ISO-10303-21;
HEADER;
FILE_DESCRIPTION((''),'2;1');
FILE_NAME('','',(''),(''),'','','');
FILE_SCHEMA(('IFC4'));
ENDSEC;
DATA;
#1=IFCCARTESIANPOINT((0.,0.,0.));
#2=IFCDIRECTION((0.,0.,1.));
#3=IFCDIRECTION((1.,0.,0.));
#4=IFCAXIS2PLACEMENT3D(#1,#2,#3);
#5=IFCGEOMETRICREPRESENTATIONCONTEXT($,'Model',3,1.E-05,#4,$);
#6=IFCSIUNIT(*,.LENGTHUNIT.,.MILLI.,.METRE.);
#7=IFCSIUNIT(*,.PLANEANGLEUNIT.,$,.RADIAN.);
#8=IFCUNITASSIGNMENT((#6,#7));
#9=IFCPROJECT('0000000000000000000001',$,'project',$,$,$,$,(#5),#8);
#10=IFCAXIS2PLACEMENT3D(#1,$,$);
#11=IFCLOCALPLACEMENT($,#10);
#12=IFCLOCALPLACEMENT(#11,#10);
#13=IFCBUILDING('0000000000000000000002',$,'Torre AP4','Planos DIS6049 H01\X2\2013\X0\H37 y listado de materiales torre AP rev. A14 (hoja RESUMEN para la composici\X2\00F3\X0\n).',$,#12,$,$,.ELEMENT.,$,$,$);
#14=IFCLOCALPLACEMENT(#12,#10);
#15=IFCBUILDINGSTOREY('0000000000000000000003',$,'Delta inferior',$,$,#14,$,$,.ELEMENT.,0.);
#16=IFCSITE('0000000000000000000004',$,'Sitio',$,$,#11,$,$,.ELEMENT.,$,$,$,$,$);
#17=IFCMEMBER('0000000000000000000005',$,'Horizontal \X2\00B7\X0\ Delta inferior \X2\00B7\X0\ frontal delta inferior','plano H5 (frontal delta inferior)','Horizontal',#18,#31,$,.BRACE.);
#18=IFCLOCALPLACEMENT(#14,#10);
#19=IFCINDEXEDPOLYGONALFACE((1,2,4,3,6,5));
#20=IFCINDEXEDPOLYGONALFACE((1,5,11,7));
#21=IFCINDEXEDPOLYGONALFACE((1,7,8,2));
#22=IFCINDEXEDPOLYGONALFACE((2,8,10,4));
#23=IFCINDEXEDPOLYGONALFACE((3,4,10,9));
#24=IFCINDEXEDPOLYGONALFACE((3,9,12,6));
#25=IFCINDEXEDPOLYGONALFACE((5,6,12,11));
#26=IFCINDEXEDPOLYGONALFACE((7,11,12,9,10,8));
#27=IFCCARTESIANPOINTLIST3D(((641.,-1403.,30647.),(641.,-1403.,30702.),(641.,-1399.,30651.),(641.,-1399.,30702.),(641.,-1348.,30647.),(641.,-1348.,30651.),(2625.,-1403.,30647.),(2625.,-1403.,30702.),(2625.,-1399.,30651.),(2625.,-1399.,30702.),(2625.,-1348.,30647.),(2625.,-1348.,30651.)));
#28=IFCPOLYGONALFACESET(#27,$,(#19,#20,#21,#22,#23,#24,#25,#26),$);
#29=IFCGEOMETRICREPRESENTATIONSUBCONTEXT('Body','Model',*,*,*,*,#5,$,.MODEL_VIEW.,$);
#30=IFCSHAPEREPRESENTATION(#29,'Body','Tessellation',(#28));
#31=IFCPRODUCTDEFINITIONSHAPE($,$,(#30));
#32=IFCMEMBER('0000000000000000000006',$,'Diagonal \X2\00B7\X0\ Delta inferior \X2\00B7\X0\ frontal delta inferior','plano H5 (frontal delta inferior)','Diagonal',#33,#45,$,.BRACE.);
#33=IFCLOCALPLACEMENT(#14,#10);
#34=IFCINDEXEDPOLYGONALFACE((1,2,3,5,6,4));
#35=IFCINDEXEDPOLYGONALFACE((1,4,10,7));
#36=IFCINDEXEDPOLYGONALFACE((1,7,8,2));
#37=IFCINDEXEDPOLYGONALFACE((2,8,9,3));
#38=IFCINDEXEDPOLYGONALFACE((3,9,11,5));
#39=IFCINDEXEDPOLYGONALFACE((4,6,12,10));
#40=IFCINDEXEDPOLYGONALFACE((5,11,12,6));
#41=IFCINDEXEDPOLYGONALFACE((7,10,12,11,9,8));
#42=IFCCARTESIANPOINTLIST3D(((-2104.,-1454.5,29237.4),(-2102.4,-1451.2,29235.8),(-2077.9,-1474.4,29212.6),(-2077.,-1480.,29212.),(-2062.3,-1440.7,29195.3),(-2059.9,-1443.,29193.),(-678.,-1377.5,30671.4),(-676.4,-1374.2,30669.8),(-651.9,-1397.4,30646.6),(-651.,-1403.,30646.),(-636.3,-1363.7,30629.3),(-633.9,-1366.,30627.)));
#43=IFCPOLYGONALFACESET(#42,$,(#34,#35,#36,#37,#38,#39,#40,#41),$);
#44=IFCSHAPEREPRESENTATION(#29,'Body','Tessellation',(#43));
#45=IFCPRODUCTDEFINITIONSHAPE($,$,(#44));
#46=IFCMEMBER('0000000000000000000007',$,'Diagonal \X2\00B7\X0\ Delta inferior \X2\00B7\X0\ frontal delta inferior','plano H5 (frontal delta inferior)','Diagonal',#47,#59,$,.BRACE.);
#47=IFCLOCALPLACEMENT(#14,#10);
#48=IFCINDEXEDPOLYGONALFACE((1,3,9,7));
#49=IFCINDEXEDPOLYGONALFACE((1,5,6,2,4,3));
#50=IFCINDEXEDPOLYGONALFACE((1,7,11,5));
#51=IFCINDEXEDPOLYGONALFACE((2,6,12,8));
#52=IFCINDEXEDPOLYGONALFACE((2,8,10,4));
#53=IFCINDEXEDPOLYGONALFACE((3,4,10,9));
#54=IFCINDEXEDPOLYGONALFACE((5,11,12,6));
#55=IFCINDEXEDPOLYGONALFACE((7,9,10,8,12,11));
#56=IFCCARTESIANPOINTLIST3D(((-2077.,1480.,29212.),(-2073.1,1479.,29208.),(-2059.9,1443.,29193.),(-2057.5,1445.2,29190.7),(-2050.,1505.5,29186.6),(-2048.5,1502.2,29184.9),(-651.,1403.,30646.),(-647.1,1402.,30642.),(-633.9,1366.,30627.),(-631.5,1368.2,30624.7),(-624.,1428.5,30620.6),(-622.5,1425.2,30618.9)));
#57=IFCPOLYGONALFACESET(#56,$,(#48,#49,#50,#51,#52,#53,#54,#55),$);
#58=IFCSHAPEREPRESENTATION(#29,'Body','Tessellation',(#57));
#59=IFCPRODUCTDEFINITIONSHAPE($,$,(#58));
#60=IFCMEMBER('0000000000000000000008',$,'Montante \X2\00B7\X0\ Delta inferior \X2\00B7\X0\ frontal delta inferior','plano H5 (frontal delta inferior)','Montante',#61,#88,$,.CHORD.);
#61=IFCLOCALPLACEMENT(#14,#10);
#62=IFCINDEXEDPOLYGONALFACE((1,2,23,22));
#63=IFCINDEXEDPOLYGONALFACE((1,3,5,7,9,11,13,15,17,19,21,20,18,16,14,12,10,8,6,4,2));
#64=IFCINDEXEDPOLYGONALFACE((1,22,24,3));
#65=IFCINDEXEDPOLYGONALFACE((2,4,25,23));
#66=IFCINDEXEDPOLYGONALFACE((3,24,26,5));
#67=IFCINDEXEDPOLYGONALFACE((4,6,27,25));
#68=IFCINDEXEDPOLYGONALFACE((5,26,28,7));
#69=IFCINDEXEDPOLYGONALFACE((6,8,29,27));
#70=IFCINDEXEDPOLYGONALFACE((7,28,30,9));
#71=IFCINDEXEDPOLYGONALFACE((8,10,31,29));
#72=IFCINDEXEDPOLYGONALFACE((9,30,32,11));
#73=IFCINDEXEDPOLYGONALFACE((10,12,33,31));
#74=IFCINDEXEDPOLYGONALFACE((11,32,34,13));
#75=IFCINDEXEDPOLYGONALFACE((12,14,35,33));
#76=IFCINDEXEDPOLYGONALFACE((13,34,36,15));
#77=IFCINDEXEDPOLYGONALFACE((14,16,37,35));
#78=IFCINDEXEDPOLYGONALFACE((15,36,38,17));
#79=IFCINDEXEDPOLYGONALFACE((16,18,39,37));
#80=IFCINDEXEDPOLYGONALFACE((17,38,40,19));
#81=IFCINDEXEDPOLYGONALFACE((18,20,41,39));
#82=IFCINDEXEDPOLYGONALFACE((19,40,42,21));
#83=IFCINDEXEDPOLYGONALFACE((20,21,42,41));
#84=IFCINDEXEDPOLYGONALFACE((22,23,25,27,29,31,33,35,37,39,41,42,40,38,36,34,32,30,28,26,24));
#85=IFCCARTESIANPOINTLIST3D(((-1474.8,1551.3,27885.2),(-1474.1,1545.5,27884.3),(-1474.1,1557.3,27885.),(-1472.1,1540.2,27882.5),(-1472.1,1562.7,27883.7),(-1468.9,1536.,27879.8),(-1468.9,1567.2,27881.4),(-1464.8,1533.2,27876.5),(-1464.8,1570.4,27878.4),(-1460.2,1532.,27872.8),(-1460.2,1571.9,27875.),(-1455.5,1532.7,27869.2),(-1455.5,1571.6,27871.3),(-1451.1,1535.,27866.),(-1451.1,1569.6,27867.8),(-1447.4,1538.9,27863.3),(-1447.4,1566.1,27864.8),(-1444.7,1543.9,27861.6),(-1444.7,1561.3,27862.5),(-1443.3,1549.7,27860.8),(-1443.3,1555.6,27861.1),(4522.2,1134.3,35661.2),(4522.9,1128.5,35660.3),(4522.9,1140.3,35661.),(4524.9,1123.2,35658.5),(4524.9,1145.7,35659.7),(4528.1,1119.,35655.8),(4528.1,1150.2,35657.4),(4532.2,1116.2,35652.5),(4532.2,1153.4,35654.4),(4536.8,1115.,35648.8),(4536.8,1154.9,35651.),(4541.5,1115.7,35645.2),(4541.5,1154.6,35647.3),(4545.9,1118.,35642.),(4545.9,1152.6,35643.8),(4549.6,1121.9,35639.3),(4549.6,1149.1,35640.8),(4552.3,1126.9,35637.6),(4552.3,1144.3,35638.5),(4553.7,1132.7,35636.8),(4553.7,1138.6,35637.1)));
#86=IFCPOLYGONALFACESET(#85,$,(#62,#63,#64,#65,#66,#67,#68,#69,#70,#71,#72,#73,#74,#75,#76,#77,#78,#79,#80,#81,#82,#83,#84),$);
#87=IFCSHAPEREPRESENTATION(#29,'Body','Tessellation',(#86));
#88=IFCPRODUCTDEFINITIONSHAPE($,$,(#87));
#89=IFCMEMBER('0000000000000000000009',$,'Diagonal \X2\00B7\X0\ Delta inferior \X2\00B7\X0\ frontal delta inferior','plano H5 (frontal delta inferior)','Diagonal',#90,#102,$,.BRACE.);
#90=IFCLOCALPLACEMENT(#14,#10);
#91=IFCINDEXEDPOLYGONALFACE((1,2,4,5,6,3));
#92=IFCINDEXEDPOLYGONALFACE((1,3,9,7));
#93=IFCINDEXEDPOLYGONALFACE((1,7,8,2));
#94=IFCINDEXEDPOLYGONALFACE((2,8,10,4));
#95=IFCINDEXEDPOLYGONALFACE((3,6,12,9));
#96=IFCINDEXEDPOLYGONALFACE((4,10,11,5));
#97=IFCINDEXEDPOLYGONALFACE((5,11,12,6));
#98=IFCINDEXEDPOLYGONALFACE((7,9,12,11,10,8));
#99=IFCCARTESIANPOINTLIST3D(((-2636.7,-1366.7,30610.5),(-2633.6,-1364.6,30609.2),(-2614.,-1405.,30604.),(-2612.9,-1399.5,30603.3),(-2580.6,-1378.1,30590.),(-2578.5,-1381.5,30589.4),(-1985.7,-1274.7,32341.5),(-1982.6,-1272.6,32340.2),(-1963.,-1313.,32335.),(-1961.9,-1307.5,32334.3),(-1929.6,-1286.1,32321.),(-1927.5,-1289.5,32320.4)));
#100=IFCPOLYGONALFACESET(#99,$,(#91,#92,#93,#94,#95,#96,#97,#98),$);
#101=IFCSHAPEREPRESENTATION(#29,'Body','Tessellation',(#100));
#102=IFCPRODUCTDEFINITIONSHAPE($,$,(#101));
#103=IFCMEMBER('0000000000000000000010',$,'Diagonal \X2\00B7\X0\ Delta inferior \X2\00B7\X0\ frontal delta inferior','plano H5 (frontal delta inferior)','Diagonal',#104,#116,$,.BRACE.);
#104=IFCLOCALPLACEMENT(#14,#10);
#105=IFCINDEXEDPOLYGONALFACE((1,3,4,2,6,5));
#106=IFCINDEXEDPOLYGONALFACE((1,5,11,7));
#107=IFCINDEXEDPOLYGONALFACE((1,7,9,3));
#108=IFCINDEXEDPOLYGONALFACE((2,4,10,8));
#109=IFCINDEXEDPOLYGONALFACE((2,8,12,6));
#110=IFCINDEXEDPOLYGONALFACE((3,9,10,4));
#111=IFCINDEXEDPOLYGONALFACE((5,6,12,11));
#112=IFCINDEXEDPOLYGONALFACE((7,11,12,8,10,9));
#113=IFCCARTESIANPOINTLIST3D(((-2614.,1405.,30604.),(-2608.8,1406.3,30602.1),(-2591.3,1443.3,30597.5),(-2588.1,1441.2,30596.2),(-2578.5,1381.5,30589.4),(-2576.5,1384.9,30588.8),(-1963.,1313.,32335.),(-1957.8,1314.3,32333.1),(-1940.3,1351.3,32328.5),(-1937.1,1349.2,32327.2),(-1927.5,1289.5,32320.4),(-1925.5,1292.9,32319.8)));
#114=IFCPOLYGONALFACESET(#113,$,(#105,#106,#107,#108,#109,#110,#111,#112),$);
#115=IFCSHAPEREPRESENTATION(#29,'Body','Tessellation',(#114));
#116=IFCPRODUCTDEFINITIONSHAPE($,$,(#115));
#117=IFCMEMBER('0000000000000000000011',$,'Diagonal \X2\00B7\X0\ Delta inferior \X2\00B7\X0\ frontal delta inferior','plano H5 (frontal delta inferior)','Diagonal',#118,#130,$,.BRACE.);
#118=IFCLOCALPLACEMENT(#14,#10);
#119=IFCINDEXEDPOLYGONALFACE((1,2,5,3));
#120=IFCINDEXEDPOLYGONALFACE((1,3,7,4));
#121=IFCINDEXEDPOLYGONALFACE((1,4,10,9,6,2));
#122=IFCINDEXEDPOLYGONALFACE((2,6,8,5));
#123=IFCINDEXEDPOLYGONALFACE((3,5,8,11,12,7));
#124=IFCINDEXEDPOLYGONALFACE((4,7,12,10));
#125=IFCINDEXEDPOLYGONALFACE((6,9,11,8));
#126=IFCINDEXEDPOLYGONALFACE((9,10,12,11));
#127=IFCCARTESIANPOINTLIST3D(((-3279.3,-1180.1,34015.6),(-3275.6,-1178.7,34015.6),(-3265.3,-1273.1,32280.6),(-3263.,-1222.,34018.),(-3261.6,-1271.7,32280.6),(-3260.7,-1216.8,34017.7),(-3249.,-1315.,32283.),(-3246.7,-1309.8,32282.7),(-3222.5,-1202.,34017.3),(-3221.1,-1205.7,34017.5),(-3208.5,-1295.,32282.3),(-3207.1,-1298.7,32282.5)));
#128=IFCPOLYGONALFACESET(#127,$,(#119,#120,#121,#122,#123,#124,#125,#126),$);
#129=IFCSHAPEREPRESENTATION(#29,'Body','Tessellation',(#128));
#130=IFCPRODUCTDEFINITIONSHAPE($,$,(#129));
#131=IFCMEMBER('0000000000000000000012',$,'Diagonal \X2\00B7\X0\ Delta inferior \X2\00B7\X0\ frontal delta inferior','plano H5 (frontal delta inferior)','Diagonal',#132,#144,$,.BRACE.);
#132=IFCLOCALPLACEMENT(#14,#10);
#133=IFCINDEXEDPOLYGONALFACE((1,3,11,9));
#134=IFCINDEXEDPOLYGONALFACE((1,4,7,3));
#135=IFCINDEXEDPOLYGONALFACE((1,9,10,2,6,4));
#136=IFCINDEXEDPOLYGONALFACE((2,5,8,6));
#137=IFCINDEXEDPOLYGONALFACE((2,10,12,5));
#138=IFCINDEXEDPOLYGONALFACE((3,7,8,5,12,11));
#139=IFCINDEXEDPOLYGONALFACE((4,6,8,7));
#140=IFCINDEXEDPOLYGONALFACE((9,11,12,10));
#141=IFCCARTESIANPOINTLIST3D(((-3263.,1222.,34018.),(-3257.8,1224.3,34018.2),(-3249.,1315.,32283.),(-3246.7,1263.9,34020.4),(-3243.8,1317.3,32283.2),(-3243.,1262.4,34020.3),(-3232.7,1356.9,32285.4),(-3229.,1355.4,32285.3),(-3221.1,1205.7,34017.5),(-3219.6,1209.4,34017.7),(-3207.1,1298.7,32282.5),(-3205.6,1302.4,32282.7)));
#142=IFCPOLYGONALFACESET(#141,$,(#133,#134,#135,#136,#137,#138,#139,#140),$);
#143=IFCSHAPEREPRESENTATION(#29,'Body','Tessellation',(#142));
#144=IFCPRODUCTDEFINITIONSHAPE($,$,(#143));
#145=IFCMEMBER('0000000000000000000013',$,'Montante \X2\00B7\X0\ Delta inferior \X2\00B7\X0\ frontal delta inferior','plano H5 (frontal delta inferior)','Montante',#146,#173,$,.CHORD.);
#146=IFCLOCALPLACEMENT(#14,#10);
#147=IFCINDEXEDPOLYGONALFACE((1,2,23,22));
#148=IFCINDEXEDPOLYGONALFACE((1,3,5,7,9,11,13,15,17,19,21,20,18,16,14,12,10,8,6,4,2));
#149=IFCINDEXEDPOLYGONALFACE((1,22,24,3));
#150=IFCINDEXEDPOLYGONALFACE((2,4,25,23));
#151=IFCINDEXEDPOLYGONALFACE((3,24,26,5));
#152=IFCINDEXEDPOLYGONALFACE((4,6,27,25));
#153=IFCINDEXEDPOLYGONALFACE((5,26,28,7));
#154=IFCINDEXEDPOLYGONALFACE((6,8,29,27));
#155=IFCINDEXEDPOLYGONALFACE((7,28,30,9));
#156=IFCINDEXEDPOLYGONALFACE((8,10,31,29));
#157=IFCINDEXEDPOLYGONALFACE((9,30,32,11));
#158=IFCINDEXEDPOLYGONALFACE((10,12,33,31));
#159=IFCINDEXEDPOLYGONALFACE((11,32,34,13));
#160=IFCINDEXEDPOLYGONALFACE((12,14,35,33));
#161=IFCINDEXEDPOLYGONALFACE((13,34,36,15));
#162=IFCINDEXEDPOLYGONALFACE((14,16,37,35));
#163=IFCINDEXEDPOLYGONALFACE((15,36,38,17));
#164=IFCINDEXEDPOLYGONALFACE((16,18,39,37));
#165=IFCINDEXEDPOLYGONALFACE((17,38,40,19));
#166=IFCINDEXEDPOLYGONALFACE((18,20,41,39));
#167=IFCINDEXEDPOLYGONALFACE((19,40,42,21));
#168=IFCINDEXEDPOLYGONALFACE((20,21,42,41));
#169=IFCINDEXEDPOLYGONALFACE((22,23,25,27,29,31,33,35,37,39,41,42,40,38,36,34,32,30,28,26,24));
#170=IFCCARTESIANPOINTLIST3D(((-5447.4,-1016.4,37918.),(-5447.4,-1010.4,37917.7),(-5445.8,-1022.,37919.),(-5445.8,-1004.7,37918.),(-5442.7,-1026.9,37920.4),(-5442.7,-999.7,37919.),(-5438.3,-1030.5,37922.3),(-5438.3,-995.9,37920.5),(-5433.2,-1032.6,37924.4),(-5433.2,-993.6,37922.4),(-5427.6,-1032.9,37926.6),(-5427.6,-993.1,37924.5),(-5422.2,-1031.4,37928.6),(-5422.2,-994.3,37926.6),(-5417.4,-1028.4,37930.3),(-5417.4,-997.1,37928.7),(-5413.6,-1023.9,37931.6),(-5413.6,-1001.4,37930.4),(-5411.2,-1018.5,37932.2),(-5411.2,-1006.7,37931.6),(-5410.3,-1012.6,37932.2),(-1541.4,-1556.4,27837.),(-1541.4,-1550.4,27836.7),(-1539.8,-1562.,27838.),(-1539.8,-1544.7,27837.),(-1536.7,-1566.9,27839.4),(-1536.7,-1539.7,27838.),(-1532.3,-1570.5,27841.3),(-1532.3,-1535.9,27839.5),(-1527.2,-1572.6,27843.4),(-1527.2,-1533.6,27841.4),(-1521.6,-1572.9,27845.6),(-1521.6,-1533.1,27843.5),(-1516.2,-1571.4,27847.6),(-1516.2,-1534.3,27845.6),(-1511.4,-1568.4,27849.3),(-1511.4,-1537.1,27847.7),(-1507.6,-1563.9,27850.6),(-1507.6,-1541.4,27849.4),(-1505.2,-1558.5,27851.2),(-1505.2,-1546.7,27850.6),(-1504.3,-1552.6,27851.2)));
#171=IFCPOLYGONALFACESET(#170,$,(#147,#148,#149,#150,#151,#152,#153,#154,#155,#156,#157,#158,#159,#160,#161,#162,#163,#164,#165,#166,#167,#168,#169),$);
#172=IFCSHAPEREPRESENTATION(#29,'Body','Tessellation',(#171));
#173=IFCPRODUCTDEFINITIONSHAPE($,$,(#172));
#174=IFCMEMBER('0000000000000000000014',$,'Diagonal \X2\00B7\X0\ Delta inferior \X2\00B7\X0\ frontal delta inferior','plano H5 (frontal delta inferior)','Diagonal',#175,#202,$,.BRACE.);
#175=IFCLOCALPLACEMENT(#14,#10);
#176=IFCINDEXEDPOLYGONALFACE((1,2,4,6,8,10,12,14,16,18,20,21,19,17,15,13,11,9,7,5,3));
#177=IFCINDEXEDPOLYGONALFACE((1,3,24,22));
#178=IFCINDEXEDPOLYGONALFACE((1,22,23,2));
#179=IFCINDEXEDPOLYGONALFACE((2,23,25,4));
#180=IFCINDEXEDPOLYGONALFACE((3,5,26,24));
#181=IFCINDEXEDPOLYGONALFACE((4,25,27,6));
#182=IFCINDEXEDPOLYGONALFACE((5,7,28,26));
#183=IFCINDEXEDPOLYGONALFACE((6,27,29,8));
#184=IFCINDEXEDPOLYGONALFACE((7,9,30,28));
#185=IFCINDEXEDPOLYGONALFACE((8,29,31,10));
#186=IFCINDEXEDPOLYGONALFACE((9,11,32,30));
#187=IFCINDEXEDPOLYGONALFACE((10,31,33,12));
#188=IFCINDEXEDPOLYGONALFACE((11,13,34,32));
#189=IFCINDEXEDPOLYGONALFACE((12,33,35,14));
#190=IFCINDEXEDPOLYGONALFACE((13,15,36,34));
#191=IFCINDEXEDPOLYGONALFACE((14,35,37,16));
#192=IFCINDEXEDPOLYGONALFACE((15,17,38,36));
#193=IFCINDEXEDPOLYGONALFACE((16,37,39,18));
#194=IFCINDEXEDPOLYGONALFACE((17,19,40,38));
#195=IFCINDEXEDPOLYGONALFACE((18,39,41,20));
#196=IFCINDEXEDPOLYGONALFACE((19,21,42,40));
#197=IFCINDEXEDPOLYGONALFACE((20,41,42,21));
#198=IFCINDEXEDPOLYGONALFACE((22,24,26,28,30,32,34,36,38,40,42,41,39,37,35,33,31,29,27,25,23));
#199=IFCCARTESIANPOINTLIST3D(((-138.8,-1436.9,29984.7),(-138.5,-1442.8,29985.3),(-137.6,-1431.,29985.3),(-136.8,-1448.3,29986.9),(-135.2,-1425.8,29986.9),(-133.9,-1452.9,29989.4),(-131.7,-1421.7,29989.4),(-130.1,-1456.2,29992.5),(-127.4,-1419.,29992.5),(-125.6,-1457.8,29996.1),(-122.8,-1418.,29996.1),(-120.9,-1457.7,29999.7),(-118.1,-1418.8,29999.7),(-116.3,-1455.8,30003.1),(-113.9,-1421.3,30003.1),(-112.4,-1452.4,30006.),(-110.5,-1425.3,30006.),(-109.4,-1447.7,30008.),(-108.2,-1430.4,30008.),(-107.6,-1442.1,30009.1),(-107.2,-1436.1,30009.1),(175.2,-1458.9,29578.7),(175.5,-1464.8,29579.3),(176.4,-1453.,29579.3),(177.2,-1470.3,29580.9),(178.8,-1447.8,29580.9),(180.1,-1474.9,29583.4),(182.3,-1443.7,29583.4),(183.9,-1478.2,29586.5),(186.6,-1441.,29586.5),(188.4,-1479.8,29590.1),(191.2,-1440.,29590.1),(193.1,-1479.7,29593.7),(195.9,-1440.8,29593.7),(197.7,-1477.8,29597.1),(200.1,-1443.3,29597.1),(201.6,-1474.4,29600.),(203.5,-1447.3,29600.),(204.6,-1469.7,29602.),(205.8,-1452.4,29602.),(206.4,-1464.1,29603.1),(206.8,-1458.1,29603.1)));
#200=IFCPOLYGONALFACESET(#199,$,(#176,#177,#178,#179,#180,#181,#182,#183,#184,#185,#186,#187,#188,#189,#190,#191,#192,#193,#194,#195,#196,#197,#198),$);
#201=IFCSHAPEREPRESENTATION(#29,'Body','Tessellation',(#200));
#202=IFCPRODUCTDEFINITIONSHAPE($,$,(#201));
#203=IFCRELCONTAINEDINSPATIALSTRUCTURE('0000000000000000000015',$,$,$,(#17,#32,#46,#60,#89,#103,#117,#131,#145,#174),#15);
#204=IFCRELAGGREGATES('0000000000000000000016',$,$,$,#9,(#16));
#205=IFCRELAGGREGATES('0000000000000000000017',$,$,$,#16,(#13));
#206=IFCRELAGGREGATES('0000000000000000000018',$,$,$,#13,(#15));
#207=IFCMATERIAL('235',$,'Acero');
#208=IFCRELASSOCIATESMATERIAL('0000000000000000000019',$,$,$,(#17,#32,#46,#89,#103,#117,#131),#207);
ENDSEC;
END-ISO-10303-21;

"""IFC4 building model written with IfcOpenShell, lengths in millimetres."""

from ifc_helpers import new_model, si_unit, frame, frame_2d, origin, origin_with_axes, place, context, subcontext, project, spatial, circle, l_section, extrude, material, element, save


model = new_model("IFC4")

# Units and contexts
model_context = context("Model", 3, precision=1e-05, world=origin_with_axes())
body_context = subcontext(model_context, "Body", "Model", "MODEL_VIEW")
ifc_project = project(units=[si_unit("LENGTHUNIT", "METRE", prefix="MILLI"), si_unit("PLANEANGLEUNIT", "RADIAN")], contexts=[model_context])

# Site, building, storey
site_placement = place(None, origin())
site = spatial("IfcSite", under=ifc_project, at=site_placement, Name="Sitio", CompositionType="ELEMENT")
building_placement = place(site_placement, origin())
building = spatial("IfcBuilding", under=site, at=building_placement, Name="Torre AP4", Description="Planos DIS6049 H01–H37 y listado de materiales torre AP rev. A14 (hoja RESUMEN para la composición).", CompositionType="ELEMENT")
storey_placement = place(building_placement, origin())
storey = spatial("IfcBuildingStorey", under=building, at=storey_placement, Name="Delta inferior", CompositionType="ELEMENT", Elevation=0.0)

# Members
ifc_material_1 = material(Name="235", Category="Acero")
member_1_placement = place(storey_placement, frame((641.0, -1403.0, 30647.0), z_axis=(1.0, 0.0, 0.0), x_axis=(0.0, 1.0, 0.0)))
element("IfcMember", 1, at=member_1_placement, inside=storey, material=ifc_material_1, Name="Horizontal · Delta inferior · frontal delta inferior", Description="plano H5 (frontal delta inferior)", ObjectType="Horizontal", PredefinedType="BRACE", context=body_context, shape_type="SweptSolid", body=[
    extrude(l_section(Depth=55.0, Width=55.0, Thickness=4.0, at=frame_2d((27.5, 27.5))), None, (0.0, 0.0, 1.0), 1984.0),
])
for number, where, z_axis, x_axis, name in (
    (2, (-2077.0, -1480.0, 29212.0), (0.704616, 0.038047, 0.708569), (0.380197, 0.822889, -0.422261), "Diagonal · Delta inferior · frontal delta inferior"),
    (3, (-2077.0, 1480.0, 29212.0), (0.704616, -0.038047, 0.708569), (0.380197, -0.822889, -0.422261), "Diagonal · Delta inferior · frontal delta inferior"),
):
    element("IfcMember", number, at=place(storey_placement, frame(where, z_axis=z_axis, x_axis=x_axis)), inside=storey, material=ifc_material_1, Name=name, Description="plano H5 (frontal delta inferior)", ObjectType="Diagonal", PredefinedType="BRACE", context=body_context, shape_type="SweptSolid", body=[
        extrude(l_section(Depth=45.0, Width=45.0, Thickness=4.0, at=frame_2d((22.5, 22.5))), None, (0.0, 0.0, 1.0), 2023.8),
    ])
for number, where, z_axis, x_axis, name in (
    (4, (-1459.0, 1552.0, 27873.0), (0.61015, -0.042427, 0.791149), (-0.792286, -0.032673, 0.609274), "Montante · Delta inferior · frontal delta inferior"),
):
    element("IfcMember", number, at=place(storey_placement, frame(where, z_axis=z_axis, x_axis=x_axis)), inside=storey, Name=name, Description="plano H5 (frontal delta inferior)", ObjectType="Montante", PredefinedType="CHORD", context=body_context, shape_type="SweptSolid", body=[
        extrude(circle(Radius=20.0), None, (0.0, 0.0, 1.0), 9828.7),
    ])
for number, where, z_axis, x_axis, name in (
    (5, (-2614.0, -1405.0, 30604.0), (0.351577, 0.049685, 0.934839), (0.788131, 0.523198, -0.32421), "Diagonal · Delta inferior · frontal delta inferior"),
    (6, (-2614.0, 1405.0, 30604.0), (0.351577, -0.049685, 0.934839), (0.788131, -0.523198, -0.32421), "Diagonal · Delta inferior · frontal delta inferior"),
):
    element("IfcMember", number, at=place(storey_placement, frame(where, z_axis=z_axis, x_axis=x_axis)), inside=storey, material=ifc_material_1, Name=name, Description="plano H5 (frontal delta inferior)", ObjectType="Diagonal", PredefinedType="BRACE", context=body_context, shape_type="SweptSolid", body=[
        extrude(l_section(Depth=45.0, Width=45.0, Thickness=4.0, at=frame_2d((22.5, 22.5))), None, (0.0, 0.0, 1.0), 1851.7),
    ])
for number, where, z_axis, x_axis, name in (
    (7, (-3249.0, -1315.0, 32283.0), (-0.008057, 0.053524, 0.998534), (0.931947, 0.3624, -0.011905), "Diagonal · Delta inferior · frontal delta inferior"),
    (8, (-3249.0, 1315.0, 32283.0), (-0.008057, -0.053524, 0.998534), (0.931947, -0.3624, -0.011905), "Diagonal · Delta inferior · frontal delta inferior"),
):
    element("IfcMember", number, at=place(storey_placement, frame(where, z_axis=z_axis, x_axis=x_axis)), inside=storey, material=ifc_material_1, Name=name, Description="plano H5 (frontal delta inferior)", ObjectType="Diagonal", PredefinedType="BRACE", context=body_context, shape_type="SweptSolid", body=[
        extrude(l_section(Depth=45.0, Width=45.0, Thickness=4.0, at=frame_2d((22.5, 22.5))), None, (0.0, 0.0, 1.0), 1737.5),
    ])
for number, where, z_axis, x_axis, name in (
    (9, (-1523.0, -1553.0, 27844.0), (-0.36084, 0.049886, 0.931293), (0.932628, 0.019301, 0.360324), "Montante · Delta inferior · frontal delta inferior"),
):
    element("IfcMember", number, at=place(storey_placement, frame(where, z_axis=z_axis, x_axis=x_axis)), inside=storey, Name=name, Description="plano H5 (frontal delta inferior)", ObjectType="Montante", PredefinedType="CHORD", context=body_context, shape_type="SweptSolid", body=[
        extrude(circle(Radius=20.0), None, (0.0, 0.0, 1.0), 10824.7),
    ])
for number, where, z_axis, x_axis, name in (
    (10, (191.0, -1460.0, 29591.0), (-0.611219, 0.042824, 0.790302), (0.011492, 0.99891, -0.04524), "Diagonal · Delta inferior · frontal delta inferior"),
):
    element("IfcMember", number, at=place(storey_placement, frame(where, z_axis=z_axis, x_axis=x_axis)), inside=storey, Name=name, Description="plano H5 (frontal delta inferior)", ObjectType="Diagonal", PredefinedType="BRACE", context=body_context, shape_type="SweptSolid", body=[
        extrude(circle(Radius=20.0), None, (0.0, 0.0, 1.0), 513.7),
    ])

save(model, "model.ifc")
